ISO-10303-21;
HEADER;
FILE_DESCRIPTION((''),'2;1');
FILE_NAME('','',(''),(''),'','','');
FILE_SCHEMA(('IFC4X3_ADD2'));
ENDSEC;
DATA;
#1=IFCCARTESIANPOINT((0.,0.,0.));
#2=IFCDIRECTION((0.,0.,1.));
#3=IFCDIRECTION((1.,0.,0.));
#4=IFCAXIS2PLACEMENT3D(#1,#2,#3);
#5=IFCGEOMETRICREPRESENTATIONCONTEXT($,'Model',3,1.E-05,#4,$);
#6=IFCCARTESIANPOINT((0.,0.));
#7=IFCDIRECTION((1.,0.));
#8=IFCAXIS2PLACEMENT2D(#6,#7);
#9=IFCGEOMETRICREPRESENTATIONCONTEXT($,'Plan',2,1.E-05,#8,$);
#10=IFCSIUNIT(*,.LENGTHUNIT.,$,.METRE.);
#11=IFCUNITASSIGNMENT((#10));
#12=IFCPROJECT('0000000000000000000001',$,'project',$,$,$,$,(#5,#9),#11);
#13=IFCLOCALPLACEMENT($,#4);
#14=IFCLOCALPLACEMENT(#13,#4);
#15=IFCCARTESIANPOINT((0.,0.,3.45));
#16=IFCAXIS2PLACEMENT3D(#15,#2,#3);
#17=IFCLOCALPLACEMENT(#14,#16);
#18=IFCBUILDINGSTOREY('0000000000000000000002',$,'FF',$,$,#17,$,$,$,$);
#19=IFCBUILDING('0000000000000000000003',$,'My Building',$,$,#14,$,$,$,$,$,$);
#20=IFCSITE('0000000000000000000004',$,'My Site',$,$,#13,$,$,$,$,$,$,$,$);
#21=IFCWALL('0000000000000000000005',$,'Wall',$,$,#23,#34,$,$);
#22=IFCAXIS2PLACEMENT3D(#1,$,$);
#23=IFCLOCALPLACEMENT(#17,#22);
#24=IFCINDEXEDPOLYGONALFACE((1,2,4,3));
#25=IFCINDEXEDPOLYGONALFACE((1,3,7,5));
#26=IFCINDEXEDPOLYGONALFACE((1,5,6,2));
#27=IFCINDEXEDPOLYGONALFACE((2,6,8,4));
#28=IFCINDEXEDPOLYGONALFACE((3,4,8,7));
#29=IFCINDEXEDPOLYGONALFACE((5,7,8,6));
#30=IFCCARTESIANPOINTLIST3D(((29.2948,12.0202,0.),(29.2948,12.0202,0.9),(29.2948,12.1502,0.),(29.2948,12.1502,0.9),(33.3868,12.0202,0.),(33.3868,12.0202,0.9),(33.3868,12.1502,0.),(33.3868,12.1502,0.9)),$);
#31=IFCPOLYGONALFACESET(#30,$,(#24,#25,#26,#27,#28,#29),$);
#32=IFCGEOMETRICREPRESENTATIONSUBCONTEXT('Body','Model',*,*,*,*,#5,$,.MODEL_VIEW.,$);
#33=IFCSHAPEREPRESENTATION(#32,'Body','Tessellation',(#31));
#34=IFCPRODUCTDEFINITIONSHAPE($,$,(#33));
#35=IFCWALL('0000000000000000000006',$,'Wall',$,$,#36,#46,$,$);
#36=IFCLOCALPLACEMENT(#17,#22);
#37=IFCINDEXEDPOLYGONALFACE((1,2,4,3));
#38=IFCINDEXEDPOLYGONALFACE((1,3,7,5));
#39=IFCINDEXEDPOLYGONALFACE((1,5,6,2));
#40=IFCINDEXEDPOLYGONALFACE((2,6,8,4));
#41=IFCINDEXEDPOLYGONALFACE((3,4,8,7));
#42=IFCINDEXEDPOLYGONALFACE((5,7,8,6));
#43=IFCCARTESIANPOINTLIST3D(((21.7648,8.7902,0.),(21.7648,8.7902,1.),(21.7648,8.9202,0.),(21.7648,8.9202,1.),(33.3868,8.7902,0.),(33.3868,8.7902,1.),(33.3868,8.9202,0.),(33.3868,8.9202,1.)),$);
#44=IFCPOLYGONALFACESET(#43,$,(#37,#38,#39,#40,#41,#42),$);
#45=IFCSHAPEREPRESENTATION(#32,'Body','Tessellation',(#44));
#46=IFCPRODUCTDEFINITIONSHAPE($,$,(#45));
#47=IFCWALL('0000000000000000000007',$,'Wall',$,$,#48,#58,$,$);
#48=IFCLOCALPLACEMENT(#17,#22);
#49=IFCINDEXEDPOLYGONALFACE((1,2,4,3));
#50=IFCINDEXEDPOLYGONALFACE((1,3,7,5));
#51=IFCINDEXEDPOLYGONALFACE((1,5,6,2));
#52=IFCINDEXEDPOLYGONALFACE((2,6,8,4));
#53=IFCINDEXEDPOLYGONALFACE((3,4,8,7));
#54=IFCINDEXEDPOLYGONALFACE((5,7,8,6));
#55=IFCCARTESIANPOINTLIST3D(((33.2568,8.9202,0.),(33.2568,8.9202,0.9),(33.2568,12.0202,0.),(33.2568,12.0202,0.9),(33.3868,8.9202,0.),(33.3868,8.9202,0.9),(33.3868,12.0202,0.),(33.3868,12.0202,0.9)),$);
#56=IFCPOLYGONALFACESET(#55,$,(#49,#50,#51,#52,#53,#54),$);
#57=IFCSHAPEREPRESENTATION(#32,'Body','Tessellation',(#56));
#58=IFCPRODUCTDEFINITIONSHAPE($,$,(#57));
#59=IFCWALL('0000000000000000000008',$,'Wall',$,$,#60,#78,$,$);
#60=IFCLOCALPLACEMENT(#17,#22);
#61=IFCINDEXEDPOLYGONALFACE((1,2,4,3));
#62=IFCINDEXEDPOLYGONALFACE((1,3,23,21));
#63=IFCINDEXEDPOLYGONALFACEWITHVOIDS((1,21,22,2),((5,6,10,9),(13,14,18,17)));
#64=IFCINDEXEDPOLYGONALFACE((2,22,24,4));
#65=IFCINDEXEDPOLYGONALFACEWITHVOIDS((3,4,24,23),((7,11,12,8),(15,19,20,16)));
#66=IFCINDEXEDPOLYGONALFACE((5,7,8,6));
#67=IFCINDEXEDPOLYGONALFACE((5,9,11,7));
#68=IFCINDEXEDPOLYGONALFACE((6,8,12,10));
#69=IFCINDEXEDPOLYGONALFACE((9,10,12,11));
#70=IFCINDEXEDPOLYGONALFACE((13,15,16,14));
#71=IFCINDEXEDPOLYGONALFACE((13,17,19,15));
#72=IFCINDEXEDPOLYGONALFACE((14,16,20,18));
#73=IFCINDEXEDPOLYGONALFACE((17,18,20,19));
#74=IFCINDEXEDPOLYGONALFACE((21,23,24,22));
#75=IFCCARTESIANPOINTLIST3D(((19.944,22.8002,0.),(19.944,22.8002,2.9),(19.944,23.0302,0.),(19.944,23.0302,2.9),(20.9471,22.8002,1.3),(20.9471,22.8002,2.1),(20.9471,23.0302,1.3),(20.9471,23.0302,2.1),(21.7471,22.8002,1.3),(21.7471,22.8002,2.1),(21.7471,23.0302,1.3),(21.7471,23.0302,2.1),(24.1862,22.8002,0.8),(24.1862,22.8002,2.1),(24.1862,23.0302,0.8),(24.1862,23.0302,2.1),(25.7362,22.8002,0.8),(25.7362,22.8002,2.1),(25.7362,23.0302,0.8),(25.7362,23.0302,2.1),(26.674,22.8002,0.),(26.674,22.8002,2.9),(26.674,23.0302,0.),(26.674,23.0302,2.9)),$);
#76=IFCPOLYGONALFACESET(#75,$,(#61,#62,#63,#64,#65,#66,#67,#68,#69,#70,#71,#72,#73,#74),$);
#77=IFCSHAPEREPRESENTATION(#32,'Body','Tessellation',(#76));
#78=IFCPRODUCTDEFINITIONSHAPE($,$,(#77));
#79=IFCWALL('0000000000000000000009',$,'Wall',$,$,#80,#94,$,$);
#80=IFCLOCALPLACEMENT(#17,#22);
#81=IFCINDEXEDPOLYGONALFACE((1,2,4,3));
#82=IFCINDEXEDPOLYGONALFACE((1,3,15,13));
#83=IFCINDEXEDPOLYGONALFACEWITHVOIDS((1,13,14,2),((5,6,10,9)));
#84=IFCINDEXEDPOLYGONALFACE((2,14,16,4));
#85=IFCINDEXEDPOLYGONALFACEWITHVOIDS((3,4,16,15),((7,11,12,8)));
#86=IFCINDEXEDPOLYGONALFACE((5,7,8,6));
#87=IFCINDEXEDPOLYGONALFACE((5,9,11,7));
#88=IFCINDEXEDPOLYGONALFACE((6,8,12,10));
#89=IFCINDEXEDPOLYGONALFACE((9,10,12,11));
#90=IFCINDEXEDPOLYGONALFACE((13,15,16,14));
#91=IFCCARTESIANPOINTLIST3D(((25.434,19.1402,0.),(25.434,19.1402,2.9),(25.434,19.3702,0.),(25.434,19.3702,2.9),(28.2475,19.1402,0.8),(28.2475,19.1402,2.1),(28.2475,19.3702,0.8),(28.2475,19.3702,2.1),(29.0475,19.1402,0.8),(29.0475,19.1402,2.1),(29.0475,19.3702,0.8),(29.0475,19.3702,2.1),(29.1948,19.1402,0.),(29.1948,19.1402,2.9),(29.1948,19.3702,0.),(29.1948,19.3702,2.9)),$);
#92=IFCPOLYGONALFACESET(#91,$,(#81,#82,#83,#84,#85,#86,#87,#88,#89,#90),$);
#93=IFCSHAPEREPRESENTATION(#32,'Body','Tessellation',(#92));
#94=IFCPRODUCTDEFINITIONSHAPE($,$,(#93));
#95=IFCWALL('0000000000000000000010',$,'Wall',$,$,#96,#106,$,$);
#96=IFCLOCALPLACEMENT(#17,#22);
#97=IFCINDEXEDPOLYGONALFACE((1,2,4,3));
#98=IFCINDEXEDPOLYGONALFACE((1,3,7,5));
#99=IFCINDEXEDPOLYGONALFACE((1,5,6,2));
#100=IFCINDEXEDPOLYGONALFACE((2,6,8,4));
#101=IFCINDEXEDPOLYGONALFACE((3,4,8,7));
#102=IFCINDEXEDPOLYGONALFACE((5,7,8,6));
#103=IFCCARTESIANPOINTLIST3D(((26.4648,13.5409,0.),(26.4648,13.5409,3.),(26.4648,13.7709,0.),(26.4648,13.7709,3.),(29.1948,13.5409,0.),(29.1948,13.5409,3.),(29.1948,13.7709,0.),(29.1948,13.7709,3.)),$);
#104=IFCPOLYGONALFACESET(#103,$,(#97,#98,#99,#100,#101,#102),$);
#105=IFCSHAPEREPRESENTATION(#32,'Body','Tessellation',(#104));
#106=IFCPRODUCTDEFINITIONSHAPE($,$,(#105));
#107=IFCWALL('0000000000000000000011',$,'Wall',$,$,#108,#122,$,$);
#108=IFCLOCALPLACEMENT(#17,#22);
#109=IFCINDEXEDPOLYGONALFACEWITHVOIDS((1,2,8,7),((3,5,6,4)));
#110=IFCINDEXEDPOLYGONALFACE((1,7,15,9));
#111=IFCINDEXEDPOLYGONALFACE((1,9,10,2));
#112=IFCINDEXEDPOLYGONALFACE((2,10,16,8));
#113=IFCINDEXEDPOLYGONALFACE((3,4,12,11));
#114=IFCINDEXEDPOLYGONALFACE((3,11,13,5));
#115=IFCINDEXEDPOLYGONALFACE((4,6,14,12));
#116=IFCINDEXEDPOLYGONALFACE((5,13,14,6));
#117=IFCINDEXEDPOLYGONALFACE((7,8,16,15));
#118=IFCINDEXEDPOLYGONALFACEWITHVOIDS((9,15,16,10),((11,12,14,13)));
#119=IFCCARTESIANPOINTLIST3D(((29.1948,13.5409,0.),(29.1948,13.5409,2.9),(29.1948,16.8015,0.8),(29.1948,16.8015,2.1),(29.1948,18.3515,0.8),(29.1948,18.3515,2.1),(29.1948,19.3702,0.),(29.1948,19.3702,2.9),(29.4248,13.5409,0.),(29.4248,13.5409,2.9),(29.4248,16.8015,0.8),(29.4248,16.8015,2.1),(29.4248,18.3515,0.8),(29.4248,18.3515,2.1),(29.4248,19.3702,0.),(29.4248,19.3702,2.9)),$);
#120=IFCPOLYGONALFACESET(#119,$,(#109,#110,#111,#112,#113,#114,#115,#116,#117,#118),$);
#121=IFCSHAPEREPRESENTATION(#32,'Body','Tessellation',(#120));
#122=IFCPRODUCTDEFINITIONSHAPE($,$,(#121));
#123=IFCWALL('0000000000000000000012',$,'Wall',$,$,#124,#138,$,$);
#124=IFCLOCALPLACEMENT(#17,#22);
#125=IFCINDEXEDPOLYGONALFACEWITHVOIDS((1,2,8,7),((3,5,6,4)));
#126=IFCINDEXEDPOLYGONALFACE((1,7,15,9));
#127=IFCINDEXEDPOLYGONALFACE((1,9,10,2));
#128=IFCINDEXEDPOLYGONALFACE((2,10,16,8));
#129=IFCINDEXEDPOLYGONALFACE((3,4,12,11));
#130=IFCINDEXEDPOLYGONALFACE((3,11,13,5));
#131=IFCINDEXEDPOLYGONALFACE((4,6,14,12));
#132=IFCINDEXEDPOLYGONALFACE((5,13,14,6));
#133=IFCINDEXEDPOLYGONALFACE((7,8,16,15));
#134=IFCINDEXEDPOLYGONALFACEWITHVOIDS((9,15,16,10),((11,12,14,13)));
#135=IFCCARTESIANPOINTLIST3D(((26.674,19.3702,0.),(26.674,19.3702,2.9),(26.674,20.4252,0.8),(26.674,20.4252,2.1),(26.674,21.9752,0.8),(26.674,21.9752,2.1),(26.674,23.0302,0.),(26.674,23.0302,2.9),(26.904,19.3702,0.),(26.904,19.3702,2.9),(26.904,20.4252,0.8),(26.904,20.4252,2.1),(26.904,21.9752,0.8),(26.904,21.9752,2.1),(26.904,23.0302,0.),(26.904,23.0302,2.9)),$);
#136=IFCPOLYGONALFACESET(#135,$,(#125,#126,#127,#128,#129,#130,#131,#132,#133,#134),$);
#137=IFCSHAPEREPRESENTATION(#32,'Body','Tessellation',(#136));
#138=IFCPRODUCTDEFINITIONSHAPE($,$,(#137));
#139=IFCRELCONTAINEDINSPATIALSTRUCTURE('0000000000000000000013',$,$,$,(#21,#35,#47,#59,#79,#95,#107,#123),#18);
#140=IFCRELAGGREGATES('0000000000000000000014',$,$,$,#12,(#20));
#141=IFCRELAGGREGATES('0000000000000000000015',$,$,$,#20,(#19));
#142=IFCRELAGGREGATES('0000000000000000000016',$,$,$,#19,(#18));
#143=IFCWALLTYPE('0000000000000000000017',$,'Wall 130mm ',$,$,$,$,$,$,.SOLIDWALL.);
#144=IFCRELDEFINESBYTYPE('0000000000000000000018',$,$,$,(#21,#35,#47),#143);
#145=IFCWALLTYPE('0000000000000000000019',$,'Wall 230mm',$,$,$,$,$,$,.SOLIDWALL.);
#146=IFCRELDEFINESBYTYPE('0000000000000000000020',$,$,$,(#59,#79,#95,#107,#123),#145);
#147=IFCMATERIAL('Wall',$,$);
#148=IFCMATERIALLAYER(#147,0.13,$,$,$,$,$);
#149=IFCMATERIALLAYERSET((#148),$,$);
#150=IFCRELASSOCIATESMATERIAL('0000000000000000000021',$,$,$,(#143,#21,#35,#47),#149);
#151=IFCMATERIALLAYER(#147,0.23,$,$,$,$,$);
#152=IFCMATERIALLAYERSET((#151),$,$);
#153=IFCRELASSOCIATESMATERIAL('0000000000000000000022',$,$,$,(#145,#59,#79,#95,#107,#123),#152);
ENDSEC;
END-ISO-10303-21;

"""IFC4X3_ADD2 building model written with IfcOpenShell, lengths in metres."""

from ifc_helpers import new_model, si_unit, frame, origin_with_axes, origin_2d_with_axis, place, context, subcontext, project, spatial, line, indexed_curve, outline, extrude, source, transform, mapped, material, layer, layer_set, layer_usage, type_object, element, save


model = new_model("IFC4X3_ADD2")

# Units and contexts
model_context = context("Model", 3, precision=1e-05, world=origin_with_axes())
plan_context = context("Plan", 2, precision=1e-05, world=origin_2d_with_axis())
body_context_1 = subcontext(model_context, "Body", "Model", "MODEL_VIEW")
ifc_project = project(units=[si_unit("LENGTHUNIT", "METRE")], contexts=[model_context, plan_context])

# Site, building, storey
site_placement = place(None, origin_with_axes())
site = spatial("IfcSite", under=ifc_project, at=site_placement, Name="My Site")
building_placement = place(site_placement, origin_with_axes())
building = spatial("IfcBuilding", under=site, at=building_placement, Name="My Building")
storey_placement = place(building_placement, frame((0.0, 0.0, 3.45), z_axis=(0.0, 0.0, 1.0), x_axis=(1.0, 0.0, 0.0)))
storey = spatial("IfcBuildingStorey", under=building, at=storey_placement, Name="FF")

# Walls
ifc_material_1 = material(Name="Wall")
ifc_layer_1 = layer(ifc_material_1, 0.13)
ifc_layer_set_1 = layer_set([ifc_layer_1])
ifc_layer_usage_1 = layer_usage(ifc_layer_set_1, "AXIS2", "POSITIVE", 0.0)
wall_type_1 = type_object("IfcWallType", Name="Wall 130mm ", PredefinedType="SOLIDWALL", material=ifc_layer_set_1)
wall_1_placement = place(storey_placement, frame((33.3868, 12.1502, 0.0), z_axis=(0.0, 0.0, 1.0), x_axis=(-1.0, 0.0, 0.0)))
element("IfcWall", 1, at=wall_1_placement, inside=storey, type_object=wall_type_1, material=ifc_layer_usage_1, Name="Wall", context=body_context_1, shape_type="SweptSolid", body=[
    extrude(outline(indexed_curve([(0.0, 0.0), (0.0, 0.13), (4.092, 0.13), (4.092, 0.0), (0.0, 0.0)], self_intersect=False)), origin_with_axes(), (0.0, 0.0, 1.0), 0.9),
])
ifc_layer_usage_2 = layer_usage(ifc_layer_set_1, "AXIS2", "POSITIVE", 0.0)
wall_2_placement = place(storey_placement, frame((33.3868, 8.9202, 0.0), z_axis=(0.0, 0.0, 1.0), x_axis=(-1.0, 0.0, 0.0)))
element("IfcWall", 2, at=wall_2_placement, inside=storey, type_object=wall_type_1, material=ifc_layer_usage_2, Name="Wall", context=body_context_1, shape_type="SweptSolid", body=[
    extrude(outline(indexed_curve([(0.0, 0.0), (0.0, 0.13), (11.622, 0.13), (11.622, 0.0), (0.0, 0.0)], self_intersect=False)), origin_with_axes(), (0.0, 0.0, 1.0), 1.0),
])
ifc_layer_usage_3 = layer_usage(ifc_layer_set_1, "AXIS2", "POSITIVE", 0.0)
wall_3_placement = place(storey_placement, frame((33.2568, 12.0202, 0.0), z_axis=(0.0, 0.0, 1.0), x_axis=(0.0, -1.0, 0.0)))
element("IfcWall", 3, at=wall_3_placement, inside=storey, type_object=wall_type_1, material=ifc_layer_usage_3, Name="Wall", context=body_context_1, shape_type="SweptSolid", body=[
    extrude(outline(indexed_curve([(0.0, 0.0), (0.0, 0.13), (3.1, 0.13), (3.1, 0.0), (0.0, 0.0)], self_intersect=False)), origin_with_axes(), (0.0, 0.0, 1.0), 0.9),
])

# Wall, openings
ifc_layer_2 = layer(ifc_material_1, 0.23)
ifc_layer_set_2 = layer_set([ifc_layer_2])
ifc_layer_usage_4 = layer_usage(ifc_layer_set_2, "AXIS2", "POSITIVE", 0.0)
wall_type_2 = type_object("IfcWallType", Name="Wall 230mm", PredefinedType="SOLIDWALL", material=ifc_layer_set_2)
wall_4_placement = place(storey_placement, frame((26.674, 23.0302, 0.0), z_axis=(0.0, 0.0, 1.0), x_axis=(-1.0, 0.0, 0.0)))
wall_4 = element("IfcWall", 4, at=wall_4_placement, inside=storey, type_object=wall_type_2, material=ifc_layer_usage_4, Name="Wall", context=body_context_1, shape_type="SweptSolid", body=[
    extrude(outline(indexed_curve([(0.0, 0.0), (0.0, 0.23), (6.73, 0.23), (6.73, 0.0), (0.0, 0.0)], self_intersect=False)), origin_with_axes(), (0.0, 0.0, 1.0), 2.9),
])
shared_shape_1 = source(origin_with_axes(), body_context_1, "Body", "SweptSolid", [
    extrude(outline(indexed_curve([(0.0, 0.0), (1.55, 0.0), (1.55, 1.3), (0.0, 1.3)], segments=[line(1, 2, 3, 4, 1)])), frame((-0.775, -0.6, 0.0), z_axis=(0.0, -1.0, 0.0), x_axis=(1.0, 0.0, 0.0)), (0.0, 0.0, -1.0), 1.2),
])
opening_1_placement = place(wall_4_placement, frame((1.7127, 0.0, 0.8), z_axis=(0.0, 0.0, 1.0), x_axis=(1.0, 0.0, 0.0)))
element("IfcOpeningElement", 5, at=opening_1_placement, cuts=wall_4, PredefinedType="OPENING", context=body_context_1, shape_type="MappedRepresentation", body=[
    mapped(shared_shape_1, transform((0.0, 0.0, 0.0), x_axis=(1.0, 0.0, 0.0), y_axis=(0.0, 1.0, 0.0), z_axis=(0.0, 0.0, 1.0), scale=1.0)),
])
shared_shape_2 = source(origin_with_axes(), body_context_1, "Body", "SweptSolid", [
    extrude(outline(indexed_curve([(0.0, 0.0), (0.8, 0.0), (0.8, 0.8), (0.0, 0.8)], segments=[line(1, 2, 3, 4, 1)])), frame((-0.4, -0.6, 0.0), z_axis=(0.0, -1.0, 0.0), x_axis=(1.0, 0.0, 0.0)), (0.0, 0.0, -1.0), 1.2),
])
opening_2_placement = place(wall_4_placement, frame((5.3269, 0.0, 1.3), z_axis=(0.0, 0.0, 1.0), x_axis=(1.0, 0.0, 0.0)))
element("IfcOpeningElement", 6, at=opening_2_placement, cuts=wall_4, PredefinedType="OPENING", context=body_context_1, shape_type="MappedRepresentation", body=[
    mapped(shared_shape_2, transform((0.0, 0.0, 0.0), x_axis=(1.0, 0.0, 0.0), y_axis=(0.0, 1.0, 0.0), z_axis=(0.0, 0.0, 1.0), scale=1.0)),
])

# Wall, opening
ifc_layer_usage_5 = layer_usage(ifc_layer_set_2, "AXIS2", "POSITIVE", 0.0)
wall_5_placement = place(storey_placement, frame((29.1948, 19.3702, 0.0), z_axis=(0.0, 0.0, 1.0), x_axis=(-1.0, 0.0, 0.0)))
wall_5 = element("IfcWall", 7, at=wall_5_placement, inside=storey, type_object=wall_type_2, material=ifc_layer_usage_5, Name="Wall", context=body_context_1, shape_type="SweptSolid", body=[
    extrude(outline(indexed_curve([(0.0, 0.0), (0.0, 0.23), (3.7608, 0.23), (3.7608, 0.0), (0.0, 0.0)], self_intersect=False)), origin_with_axes(), (0.0, 0.0, 1.0), 2.9),
])
shared_shape_3 = source(origin_with_axes(), body_context_1, "Body", "SweptSolid", [
    extrude(outline(indexed_curve([(0.0, 0.0), (0.8, 0.0), (0.8, 1.3), (0.0, 1.3)], segments=[line(1, 2, 3, 4, 1)])), frame((-0.4, -0.6, 0.0), z_axis=(0.0, -1.0, 0.0), x_axis=(1.0, 0.0, 0.0)), (0.0, 0.0, -1.0), 1.2),
])
opening_3_placement = place(wall_5_placement, frame((0.5473, 0.0, 0.8), z_axis=(0.0, 0.0, 1.0), x_axis=(1.0, 0.0, 0.0)))
element("IfcOpeningElement", 8, at=opening_3_placement, cuts=wall_5, PredefinedType="OPENING", context=body_context_1, shape_type="MappedRepresentation", body=[
    mapped(shared_shape_3, transform((0.0, 0.0, 0.0), x_axis=(1.0, 0.0, 0.0), y_axis=(0.0, 1.0, 0.0), z_axis=(0.0, 0.0, 1.0), scale=1.0)),
])

# Wall
ifc_layer_usage_6 = layer_usage(ifc_layer_set_2, "AXIS2", "POSITIVE", 0.0)
wall_6_placement = place(storey_placement, frame((29.1948, 13.7709, 0.0), z_axis=(0.0, 0.0, 1.0), x_axis=(-1.0, 0.0, 0.0)))
element("IfcWall", 9, at=wall_6_placement, inside=storey, type_object=wall_type_2, material=ifc_layer_usage_6, Name="Wall", context=body_context_1, shape_type="SweptSolid", body=[
    extrude(outline(indexed_curve([(0.0, 0.0), (0.0, 0.23), (2.73, 0.23), (2.73, 0.0), (0.0, 0.0)], self_intersect=False)), origin_with_axes(), (0.0, 0.0, 1.0), 3.0),
])

# Walls, openings
ifc_layer_usage_7 = layer_usage(ifc_layer_set_2, "AXIS2", "POSITIVE", 0.0)
wall_7_placement = place(storey_placement, frame((29.4248, 13.5409, 0.0), z_axis=(0.0, 0.0, 1.0), x_axis=(0.000001, 1.0, 0.0)))
wall_7 = element("IfcWall", 10, at=wall_7_placement, inside=storey, type_object=wall_type_2, material=ifc_layer_usage_7, Name="Wall", context=body_context_1, shape_type="SweptSolid", body=[
    extrude(outline(indexed_curve([(0.0, 0.0), (0.0, 0.23), (5.8293, 0.23), (5.8293, 0.0), (0.0, 0.0)], self_intersect=False)), origin_with_axes(), (0.0, 0.0, 1.0), 2.9),
])
opening_4_placement = place(wall_7_placement, frame((4.0356, 0.0, 0.8), z_axis=(0.0, 0.0, 1.0), x_axis=(1.0, 0.0, 0.0)))
element("IfcOpeningElement", 11, at=opening_4_placement, cuts=wall_7, PredefinedType="OPENING", context=body_context_1, shape_type="MappedRepresentation", body=[
    mapped(shared_shape_1, transform((0.0, 0.0, 0.0), x_axis=(1.0, 0.0, 0.0), y_axis=(0.0, 1.0, 0.0), z_axis=(0.0, 0.0, 1.0), scale=1.0)),
])
ifc_layer_usage_8 = layer_usage(ifc_layer_set_2, "AXIS2", "POSITIVE", 0.0)
wall_8_placement = place(storey_placement, frame((26.904, 19.3702, 0.0), z_axis=(0.0, 0.0, 1.0), x_axis=(0.000001, 1.0, 0.0)))
wall_8 = element("IfcWall", 12, at=wall_8_placement, inside=storey, type_object=wall_type_2, material=ifc_layer_usage_8, Name="Wall", context=body_context_1, shape_type="SweptSolid", body=[
    extrude(outline(indexed_curve([(0.0, 0.0), (0.0, 0.23), (3.66, 0.23), (3.66, 0.0), (0.0, 0.0)], self_intersect=False)), origin_with_axes(), (0.0, 0.0, 1.0), 2.9),
])
opening_5_placement = place(wall_8_placement, frame((1.83, 0.0, 0.8), z_axis=(0.0, 0.0, 1.0), x_axis=(1.0, 0.0, 0.0)))
element("IfcOpeningElement", 13, at=opening_5_placement, cuts=wall_8, PredefinedType="OPENING", context=body_context_1, shape_type="MappedRepresentation", body=[
    mapped(shared_shape_1, transform((0.0, 0.0, 0.0), x_axis=(1.0, 0.0, 0.0), y_axis=(0.0, 1.0, 0.0), z_axis=(0.0, 0.0, 1.0), scale=1.0)),
])

save(model, "model.ifc")
